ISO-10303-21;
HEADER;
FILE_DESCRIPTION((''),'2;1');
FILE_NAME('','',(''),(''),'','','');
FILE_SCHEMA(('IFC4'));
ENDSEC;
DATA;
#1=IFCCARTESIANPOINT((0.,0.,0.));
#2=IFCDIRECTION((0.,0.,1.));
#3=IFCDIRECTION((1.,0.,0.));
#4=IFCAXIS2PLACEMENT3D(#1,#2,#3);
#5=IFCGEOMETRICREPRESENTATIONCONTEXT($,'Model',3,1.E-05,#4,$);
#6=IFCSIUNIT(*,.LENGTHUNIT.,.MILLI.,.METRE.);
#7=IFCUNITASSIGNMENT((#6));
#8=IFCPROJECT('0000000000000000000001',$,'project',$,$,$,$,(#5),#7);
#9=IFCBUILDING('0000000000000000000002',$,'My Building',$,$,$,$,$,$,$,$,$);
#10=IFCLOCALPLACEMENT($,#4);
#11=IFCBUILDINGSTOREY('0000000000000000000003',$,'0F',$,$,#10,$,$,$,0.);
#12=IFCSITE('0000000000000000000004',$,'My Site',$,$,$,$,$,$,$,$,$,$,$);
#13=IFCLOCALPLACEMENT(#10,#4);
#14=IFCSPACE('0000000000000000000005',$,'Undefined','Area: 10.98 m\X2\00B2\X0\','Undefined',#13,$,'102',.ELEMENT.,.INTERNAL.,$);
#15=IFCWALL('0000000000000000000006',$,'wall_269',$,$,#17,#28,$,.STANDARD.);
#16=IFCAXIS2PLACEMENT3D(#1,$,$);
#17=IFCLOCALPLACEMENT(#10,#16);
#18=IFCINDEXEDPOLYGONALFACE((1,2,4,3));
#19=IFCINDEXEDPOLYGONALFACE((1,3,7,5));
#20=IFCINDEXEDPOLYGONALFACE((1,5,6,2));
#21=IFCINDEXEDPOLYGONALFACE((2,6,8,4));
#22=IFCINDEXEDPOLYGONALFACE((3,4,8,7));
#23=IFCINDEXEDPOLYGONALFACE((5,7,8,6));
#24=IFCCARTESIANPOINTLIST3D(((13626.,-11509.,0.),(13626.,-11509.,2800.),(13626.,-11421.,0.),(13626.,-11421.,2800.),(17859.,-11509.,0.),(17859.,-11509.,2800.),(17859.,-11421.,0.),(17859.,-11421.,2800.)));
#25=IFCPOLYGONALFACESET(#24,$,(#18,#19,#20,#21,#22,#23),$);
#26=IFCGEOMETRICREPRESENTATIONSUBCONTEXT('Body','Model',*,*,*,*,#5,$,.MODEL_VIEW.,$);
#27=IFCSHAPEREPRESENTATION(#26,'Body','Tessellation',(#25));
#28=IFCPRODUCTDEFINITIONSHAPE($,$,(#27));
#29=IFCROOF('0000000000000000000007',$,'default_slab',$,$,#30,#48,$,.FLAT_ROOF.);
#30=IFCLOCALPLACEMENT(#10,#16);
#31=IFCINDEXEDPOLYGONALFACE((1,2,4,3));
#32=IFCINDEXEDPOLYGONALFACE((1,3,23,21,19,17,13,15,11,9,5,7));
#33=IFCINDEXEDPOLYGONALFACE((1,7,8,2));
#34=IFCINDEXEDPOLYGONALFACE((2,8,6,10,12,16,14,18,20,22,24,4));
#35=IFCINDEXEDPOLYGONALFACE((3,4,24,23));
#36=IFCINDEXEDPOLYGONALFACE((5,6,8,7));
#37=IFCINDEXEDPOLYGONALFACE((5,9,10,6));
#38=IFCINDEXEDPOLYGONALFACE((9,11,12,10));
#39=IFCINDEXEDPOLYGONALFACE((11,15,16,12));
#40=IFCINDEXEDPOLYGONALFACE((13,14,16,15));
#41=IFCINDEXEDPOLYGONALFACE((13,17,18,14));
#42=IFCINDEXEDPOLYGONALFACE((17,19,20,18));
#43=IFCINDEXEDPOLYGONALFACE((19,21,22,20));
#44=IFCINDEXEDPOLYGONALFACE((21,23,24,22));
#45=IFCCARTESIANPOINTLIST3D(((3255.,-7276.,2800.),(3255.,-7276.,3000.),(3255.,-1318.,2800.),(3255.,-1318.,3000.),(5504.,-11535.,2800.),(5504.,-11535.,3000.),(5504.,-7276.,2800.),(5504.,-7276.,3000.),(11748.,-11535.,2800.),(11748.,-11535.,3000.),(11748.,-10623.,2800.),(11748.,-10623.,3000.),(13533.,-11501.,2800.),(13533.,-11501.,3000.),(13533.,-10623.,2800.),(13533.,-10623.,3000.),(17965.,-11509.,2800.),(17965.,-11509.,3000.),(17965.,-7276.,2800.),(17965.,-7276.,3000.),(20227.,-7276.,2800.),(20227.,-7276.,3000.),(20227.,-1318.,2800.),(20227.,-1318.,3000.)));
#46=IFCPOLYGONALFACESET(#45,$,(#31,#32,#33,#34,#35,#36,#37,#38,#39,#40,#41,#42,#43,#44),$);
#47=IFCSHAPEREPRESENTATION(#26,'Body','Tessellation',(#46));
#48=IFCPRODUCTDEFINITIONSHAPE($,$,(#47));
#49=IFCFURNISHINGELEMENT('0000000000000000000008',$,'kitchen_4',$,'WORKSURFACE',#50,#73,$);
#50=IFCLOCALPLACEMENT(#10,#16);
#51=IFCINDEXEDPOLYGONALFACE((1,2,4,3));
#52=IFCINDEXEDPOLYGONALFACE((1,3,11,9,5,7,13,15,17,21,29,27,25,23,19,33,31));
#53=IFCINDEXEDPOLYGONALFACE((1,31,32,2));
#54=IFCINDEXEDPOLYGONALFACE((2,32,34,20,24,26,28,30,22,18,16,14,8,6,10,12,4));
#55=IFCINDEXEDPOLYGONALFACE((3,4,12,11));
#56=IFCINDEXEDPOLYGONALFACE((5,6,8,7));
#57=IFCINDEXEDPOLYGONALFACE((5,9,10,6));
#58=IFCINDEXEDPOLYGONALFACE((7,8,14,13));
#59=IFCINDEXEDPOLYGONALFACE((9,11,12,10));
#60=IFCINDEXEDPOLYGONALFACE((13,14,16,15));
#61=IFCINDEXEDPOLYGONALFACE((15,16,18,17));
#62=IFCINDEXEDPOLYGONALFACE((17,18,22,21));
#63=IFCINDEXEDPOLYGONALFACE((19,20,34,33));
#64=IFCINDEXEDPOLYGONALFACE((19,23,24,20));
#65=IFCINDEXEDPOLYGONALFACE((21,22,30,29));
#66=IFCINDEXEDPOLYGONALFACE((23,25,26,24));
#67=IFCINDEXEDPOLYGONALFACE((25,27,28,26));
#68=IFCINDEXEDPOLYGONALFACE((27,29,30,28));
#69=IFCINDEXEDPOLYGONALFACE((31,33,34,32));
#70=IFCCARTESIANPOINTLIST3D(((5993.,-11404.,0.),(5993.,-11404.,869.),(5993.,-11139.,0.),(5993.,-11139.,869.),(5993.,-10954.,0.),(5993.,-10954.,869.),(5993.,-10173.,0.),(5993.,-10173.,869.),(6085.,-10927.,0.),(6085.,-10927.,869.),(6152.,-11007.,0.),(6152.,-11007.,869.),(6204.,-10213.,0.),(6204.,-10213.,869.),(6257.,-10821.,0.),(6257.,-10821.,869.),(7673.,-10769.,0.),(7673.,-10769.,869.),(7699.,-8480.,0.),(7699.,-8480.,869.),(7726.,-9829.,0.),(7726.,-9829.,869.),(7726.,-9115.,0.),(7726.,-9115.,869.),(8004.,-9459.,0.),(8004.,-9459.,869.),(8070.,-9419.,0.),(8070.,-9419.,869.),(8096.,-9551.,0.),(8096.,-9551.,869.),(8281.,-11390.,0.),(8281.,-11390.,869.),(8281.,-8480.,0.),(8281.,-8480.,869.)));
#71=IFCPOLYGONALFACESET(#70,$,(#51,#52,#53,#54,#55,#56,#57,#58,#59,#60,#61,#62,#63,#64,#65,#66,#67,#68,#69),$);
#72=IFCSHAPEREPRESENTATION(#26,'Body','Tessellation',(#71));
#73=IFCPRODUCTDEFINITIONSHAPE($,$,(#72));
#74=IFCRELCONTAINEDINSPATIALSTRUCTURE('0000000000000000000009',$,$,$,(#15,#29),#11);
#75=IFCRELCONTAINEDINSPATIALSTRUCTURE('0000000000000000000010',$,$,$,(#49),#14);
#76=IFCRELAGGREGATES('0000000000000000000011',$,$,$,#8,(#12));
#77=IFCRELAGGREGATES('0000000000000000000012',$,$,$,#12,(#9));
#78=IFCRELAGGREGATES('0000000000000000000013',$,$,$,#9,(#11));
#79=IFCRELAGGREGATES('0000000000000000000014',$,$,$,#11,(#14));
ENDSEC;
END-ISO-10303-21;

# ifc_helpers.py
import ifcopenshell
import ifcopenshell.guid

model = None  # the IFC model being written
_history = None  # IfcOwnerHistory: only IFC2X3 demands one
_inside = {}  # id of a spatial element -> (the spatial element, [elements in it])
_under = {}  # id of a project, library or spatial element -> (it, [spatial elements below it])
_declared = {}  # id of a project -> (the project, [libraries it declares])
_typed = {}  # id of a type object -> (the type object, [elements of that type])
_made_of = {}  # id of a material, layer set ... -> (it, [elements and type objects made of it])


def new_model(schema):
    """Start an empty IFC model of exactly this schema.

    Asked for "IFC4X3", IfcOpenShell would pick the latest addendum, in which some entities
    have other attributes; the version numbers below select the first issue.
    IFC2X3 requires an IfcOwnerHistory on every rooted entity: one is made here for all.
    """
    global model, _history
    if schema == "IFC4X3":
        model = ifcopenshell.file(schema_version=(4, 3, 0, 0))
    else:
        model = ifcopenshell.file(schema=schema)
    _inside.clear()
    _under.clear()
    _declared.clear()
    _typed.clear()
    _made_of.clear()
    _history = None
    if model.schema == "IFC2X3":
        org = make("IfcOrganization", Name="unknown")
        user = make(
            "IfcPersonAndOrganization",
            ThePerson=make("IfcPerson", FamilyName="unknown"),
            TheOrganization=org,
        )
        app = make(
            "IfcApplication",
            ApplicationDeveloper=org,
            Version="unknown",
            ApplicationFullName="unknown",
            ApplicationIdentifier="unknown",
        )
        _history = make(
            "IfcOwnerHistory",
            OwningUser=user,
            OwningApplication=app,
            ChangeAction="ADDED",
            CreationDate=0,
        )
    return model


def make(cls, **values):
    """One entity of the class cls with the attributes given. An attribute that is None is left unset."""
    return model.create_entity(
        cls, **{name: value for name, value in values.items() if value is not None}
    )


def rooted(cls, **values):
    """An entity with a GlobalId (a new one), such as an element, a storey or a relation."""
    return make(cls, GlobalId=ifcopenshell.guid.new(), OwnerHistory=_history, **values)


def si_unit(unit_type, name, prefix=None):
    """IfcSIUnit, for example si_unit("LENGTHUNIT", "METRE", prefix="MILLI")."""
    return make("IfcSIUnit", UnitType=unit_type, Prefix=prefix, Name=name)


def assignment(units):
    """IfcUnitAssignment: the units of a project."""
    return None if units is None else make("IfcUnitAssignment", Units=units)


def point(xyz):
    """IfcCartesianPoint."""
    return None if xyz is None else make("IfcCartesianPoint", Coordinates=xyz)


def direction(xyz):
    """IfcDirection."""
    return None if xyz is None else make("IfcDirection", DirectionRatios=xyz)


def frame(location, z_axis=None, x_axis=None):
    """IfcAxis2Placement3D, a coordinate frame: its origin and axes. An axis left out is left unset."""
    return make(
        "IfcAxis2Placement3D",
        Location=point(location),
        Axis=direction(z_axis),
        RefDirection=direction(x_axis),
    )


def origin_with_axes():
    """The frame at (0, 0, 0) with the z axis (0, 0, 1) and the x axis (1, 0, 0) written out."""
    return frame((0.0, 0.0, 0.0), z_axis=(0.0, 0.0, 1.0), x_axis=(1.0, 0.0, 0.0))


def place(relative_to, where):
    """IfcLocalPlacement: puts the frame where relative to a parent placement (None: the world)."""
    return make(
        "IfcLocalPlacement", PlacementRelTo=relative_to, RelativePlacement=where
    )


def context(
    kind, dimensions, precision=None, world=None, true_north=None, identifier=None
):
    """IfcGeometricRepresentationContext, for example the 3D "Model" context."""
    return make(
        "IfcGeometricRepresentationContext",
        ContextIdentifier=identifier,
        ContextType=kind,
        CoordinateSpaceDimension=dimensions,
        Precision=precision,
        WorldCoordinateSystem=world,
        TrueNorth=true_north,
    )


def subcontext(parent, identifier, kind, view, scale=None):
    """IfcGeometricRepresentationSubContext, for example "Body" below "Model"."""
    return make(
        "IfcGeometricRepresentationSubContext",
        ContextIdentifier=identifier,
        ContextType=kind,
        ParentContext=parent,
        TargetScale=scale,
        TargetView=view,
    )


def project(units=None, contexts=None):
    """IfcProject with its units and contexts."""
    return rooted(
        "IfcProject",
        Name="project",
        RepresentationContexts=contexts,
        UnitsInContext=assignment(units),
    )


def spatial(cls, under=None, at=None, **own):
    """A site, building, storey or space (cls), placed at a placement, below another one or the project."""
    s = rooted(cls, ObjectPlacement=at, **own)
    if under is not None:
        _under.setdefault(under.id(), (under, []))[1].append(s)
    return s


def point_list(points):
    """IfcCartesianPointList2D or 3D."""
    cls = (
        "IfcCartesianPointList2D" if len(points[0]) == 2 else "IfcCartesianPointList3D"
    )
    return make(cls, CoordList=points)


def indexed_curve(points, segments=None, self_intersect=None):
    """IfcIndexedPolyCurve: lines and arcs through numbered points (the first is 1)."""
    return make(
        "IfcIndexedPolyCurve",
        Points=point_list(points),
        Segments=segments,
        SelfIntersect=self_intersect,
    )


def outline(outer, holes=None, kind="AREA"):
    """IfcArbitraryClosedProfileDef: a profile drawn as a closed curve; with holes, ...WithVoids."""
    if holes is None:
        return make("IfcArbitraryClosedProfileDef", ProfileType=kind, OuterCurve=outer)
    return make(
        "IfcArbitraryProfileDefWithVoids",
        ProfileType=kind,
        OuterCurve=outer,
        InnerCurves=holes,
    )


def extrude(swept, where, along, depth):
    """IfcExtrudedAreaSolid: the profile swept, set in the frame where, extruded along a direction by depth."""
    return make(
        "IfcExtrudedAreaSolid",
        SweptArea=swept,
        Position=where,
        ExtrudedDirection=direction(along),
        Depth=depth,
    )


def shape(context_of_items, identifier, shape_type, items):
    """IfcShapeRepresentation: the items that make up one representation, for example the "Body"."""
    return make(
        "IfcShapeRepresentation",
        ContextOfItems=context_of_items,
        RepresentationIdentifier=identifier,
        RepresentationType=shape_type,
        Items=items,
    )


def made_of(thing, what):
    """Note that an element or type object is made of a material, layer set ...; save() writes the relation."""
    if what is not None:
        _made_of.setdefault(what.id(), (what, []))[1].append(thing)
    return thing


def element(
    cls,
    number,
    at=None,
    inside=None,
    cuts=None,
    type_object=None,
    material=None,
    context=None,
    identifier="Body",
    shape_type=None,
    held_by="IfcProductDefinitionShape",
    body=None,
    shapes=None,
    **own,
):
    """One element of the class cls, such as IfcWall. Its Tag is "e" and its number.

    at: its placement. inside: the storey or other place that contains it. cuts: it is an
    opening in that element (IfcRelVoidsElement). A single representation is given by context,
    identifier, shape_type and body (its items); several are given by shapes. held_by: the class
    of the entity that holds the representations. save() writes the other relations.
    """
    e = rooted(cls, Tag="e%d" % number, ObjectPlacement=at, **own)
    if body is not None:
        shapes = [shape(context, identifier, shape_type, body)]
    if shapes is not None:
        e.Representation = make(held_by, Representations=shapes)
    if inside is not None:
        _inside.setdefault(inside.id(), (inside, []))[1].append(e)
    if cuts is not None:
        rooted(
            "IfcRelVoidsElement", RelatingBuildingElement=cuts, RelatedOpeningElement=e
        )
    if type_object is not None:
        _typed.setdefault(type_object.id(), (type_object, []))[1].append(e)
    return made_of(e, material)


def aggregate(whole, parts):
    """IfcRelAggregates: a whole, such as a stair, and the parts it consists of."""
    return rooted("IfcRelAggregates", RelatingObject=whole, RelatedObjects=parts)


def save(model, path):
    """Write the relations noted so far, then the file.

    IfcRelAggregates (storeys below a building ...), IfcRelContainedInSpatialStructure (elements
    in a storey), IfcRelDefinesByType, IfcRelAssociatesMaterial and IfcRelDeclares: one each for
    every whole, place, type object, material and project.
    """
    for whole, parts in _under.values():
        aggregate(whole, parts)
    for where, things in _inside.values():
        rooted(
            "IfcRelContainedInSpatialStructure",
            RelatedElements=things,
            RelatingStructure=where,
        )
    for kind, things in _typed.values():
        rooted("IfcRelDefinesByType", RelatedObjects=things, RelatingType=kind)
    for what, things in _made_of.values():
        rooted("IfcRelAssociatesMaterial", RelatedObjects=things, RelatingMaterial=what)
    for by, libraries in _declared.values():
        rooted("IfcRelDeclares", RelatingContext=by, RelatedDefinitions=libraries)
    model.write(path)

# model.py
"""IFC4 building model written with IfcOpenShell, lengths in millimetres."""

from ifc_helpers import new_model, si_unit, frame, origin_with_axes, place, context, subcontext, project, spatial, indexed_curve, outline, extrude, element, save


model = new_model("IFC4")

# Units and contexts
model_context = context("Model", 3, precision=1e-05, world=origin_with_axes())
body_context = subcontext(model_context, "Body", "Model", "MODEL_VIEW")
ifc_project = project(units=[si_unit("LENGTHUNIT", "METRE", prefix="MILLI")], contexts=[model_context])

# Site, building, storey
site = spatial("IfcSite", under=ifc_project, Name="My Site")
building = spatial("IfcBuilding", under=site, Name="My Building")
storey_placement = place(None, origin_with_axes())
storey = spatial("IfcBuildingStorey", under=building, at=storey_placement, Name="0F", Elevation=0.0)

# Wall
wall_1_placement = place(storey_placement, origin_with_axes())
element("IfcWall", 1, at=wall_1_placement, inside=storey, Name="wall_269", PredefinedType="STANDARD", context=body_context, shape_type="SweptSolid", body=[
    extrude(outline(indexed_curve([(13626.0, -11509.0), (17859.0, -11509.0), (17859.0, -11421.0), (13626.0, -11421.0), (13626.0, -11509.0)])), None, (0.0, 0.0, 1.0), 2800.0),
])

# Roof
roof_placement = place(storey_placement, frame((0.0, 0.0, 3000.0), z_axis=(0.0, 0.0, 1.0), x_axis=(1.0, 0.0, 0.0)))
element("IfcRoof", 2, at=roof_placement, inside=storey, Name="default_slab", PredefinedType="FLAT_ROOF", context=body_context, shape_type="SweptSolid", body=[
    extrude(outline(indexed_curve([(5504.0, -7276.0), (5504.0, -11535.0), (11748.0, -11535.0), (11748.0, -10623.0), (13533.0, -10623.0), (13533.0, -11501.0), (17965.0, -11509.0), (17965.0, -7276.0), (20227.0, -7276.0), (20227.0, -1318.0), (3255.0, -1318.0), (3255.0, -7276.0), (5504.0, -7276.0)])), None, (0.0, 0.0, -1.0), 200.0),
])

# Shared definitions
space_placement = place(storey_placement, origin_with_axes())
space = spatial("IfcSpace", under=storey, at=space_placement, Name="Undefined", Description="Area: 10.98 m²", ObjectType="Undefined", LongName="102", CompositionType="ELEMENT", PredefinedType="INTERNAL")

# Furnishing element
furnishing_placement = place(space_placement, origin_with_axes())
element("IfcFurnishingElement", 3, at=furnishing_placement, inside=space, Name="kitchen_4", ObjectType="WORKSURFACE", context=body_context, shape_type="SweptSolid", body=[
    extrude(outline(indexed_curve([(7699.0, -8480.0), (7726.0, -9115.0), (8004.0, -9459.0), (8070.0, -9419.0), (8096.0, -9551.0), (7726.0, -9829.0), (7673.0, -10769.0), (6257.0, -10821.0), (6204.0, -10213.0), (5993.0, -10173.0), (5993.0, -10954.0), (6085.0, -10927.0), (6152.0, -11007.0), (5993.0, -11139.0), (5993.0, -11404.0), (8281.0, -11390.0), (8281.0, -8480.0), (7699.0, -8480.0)])), None, (0.0, 0.0, 1.0), 869.0),
])

save(model, "model.ifc")
